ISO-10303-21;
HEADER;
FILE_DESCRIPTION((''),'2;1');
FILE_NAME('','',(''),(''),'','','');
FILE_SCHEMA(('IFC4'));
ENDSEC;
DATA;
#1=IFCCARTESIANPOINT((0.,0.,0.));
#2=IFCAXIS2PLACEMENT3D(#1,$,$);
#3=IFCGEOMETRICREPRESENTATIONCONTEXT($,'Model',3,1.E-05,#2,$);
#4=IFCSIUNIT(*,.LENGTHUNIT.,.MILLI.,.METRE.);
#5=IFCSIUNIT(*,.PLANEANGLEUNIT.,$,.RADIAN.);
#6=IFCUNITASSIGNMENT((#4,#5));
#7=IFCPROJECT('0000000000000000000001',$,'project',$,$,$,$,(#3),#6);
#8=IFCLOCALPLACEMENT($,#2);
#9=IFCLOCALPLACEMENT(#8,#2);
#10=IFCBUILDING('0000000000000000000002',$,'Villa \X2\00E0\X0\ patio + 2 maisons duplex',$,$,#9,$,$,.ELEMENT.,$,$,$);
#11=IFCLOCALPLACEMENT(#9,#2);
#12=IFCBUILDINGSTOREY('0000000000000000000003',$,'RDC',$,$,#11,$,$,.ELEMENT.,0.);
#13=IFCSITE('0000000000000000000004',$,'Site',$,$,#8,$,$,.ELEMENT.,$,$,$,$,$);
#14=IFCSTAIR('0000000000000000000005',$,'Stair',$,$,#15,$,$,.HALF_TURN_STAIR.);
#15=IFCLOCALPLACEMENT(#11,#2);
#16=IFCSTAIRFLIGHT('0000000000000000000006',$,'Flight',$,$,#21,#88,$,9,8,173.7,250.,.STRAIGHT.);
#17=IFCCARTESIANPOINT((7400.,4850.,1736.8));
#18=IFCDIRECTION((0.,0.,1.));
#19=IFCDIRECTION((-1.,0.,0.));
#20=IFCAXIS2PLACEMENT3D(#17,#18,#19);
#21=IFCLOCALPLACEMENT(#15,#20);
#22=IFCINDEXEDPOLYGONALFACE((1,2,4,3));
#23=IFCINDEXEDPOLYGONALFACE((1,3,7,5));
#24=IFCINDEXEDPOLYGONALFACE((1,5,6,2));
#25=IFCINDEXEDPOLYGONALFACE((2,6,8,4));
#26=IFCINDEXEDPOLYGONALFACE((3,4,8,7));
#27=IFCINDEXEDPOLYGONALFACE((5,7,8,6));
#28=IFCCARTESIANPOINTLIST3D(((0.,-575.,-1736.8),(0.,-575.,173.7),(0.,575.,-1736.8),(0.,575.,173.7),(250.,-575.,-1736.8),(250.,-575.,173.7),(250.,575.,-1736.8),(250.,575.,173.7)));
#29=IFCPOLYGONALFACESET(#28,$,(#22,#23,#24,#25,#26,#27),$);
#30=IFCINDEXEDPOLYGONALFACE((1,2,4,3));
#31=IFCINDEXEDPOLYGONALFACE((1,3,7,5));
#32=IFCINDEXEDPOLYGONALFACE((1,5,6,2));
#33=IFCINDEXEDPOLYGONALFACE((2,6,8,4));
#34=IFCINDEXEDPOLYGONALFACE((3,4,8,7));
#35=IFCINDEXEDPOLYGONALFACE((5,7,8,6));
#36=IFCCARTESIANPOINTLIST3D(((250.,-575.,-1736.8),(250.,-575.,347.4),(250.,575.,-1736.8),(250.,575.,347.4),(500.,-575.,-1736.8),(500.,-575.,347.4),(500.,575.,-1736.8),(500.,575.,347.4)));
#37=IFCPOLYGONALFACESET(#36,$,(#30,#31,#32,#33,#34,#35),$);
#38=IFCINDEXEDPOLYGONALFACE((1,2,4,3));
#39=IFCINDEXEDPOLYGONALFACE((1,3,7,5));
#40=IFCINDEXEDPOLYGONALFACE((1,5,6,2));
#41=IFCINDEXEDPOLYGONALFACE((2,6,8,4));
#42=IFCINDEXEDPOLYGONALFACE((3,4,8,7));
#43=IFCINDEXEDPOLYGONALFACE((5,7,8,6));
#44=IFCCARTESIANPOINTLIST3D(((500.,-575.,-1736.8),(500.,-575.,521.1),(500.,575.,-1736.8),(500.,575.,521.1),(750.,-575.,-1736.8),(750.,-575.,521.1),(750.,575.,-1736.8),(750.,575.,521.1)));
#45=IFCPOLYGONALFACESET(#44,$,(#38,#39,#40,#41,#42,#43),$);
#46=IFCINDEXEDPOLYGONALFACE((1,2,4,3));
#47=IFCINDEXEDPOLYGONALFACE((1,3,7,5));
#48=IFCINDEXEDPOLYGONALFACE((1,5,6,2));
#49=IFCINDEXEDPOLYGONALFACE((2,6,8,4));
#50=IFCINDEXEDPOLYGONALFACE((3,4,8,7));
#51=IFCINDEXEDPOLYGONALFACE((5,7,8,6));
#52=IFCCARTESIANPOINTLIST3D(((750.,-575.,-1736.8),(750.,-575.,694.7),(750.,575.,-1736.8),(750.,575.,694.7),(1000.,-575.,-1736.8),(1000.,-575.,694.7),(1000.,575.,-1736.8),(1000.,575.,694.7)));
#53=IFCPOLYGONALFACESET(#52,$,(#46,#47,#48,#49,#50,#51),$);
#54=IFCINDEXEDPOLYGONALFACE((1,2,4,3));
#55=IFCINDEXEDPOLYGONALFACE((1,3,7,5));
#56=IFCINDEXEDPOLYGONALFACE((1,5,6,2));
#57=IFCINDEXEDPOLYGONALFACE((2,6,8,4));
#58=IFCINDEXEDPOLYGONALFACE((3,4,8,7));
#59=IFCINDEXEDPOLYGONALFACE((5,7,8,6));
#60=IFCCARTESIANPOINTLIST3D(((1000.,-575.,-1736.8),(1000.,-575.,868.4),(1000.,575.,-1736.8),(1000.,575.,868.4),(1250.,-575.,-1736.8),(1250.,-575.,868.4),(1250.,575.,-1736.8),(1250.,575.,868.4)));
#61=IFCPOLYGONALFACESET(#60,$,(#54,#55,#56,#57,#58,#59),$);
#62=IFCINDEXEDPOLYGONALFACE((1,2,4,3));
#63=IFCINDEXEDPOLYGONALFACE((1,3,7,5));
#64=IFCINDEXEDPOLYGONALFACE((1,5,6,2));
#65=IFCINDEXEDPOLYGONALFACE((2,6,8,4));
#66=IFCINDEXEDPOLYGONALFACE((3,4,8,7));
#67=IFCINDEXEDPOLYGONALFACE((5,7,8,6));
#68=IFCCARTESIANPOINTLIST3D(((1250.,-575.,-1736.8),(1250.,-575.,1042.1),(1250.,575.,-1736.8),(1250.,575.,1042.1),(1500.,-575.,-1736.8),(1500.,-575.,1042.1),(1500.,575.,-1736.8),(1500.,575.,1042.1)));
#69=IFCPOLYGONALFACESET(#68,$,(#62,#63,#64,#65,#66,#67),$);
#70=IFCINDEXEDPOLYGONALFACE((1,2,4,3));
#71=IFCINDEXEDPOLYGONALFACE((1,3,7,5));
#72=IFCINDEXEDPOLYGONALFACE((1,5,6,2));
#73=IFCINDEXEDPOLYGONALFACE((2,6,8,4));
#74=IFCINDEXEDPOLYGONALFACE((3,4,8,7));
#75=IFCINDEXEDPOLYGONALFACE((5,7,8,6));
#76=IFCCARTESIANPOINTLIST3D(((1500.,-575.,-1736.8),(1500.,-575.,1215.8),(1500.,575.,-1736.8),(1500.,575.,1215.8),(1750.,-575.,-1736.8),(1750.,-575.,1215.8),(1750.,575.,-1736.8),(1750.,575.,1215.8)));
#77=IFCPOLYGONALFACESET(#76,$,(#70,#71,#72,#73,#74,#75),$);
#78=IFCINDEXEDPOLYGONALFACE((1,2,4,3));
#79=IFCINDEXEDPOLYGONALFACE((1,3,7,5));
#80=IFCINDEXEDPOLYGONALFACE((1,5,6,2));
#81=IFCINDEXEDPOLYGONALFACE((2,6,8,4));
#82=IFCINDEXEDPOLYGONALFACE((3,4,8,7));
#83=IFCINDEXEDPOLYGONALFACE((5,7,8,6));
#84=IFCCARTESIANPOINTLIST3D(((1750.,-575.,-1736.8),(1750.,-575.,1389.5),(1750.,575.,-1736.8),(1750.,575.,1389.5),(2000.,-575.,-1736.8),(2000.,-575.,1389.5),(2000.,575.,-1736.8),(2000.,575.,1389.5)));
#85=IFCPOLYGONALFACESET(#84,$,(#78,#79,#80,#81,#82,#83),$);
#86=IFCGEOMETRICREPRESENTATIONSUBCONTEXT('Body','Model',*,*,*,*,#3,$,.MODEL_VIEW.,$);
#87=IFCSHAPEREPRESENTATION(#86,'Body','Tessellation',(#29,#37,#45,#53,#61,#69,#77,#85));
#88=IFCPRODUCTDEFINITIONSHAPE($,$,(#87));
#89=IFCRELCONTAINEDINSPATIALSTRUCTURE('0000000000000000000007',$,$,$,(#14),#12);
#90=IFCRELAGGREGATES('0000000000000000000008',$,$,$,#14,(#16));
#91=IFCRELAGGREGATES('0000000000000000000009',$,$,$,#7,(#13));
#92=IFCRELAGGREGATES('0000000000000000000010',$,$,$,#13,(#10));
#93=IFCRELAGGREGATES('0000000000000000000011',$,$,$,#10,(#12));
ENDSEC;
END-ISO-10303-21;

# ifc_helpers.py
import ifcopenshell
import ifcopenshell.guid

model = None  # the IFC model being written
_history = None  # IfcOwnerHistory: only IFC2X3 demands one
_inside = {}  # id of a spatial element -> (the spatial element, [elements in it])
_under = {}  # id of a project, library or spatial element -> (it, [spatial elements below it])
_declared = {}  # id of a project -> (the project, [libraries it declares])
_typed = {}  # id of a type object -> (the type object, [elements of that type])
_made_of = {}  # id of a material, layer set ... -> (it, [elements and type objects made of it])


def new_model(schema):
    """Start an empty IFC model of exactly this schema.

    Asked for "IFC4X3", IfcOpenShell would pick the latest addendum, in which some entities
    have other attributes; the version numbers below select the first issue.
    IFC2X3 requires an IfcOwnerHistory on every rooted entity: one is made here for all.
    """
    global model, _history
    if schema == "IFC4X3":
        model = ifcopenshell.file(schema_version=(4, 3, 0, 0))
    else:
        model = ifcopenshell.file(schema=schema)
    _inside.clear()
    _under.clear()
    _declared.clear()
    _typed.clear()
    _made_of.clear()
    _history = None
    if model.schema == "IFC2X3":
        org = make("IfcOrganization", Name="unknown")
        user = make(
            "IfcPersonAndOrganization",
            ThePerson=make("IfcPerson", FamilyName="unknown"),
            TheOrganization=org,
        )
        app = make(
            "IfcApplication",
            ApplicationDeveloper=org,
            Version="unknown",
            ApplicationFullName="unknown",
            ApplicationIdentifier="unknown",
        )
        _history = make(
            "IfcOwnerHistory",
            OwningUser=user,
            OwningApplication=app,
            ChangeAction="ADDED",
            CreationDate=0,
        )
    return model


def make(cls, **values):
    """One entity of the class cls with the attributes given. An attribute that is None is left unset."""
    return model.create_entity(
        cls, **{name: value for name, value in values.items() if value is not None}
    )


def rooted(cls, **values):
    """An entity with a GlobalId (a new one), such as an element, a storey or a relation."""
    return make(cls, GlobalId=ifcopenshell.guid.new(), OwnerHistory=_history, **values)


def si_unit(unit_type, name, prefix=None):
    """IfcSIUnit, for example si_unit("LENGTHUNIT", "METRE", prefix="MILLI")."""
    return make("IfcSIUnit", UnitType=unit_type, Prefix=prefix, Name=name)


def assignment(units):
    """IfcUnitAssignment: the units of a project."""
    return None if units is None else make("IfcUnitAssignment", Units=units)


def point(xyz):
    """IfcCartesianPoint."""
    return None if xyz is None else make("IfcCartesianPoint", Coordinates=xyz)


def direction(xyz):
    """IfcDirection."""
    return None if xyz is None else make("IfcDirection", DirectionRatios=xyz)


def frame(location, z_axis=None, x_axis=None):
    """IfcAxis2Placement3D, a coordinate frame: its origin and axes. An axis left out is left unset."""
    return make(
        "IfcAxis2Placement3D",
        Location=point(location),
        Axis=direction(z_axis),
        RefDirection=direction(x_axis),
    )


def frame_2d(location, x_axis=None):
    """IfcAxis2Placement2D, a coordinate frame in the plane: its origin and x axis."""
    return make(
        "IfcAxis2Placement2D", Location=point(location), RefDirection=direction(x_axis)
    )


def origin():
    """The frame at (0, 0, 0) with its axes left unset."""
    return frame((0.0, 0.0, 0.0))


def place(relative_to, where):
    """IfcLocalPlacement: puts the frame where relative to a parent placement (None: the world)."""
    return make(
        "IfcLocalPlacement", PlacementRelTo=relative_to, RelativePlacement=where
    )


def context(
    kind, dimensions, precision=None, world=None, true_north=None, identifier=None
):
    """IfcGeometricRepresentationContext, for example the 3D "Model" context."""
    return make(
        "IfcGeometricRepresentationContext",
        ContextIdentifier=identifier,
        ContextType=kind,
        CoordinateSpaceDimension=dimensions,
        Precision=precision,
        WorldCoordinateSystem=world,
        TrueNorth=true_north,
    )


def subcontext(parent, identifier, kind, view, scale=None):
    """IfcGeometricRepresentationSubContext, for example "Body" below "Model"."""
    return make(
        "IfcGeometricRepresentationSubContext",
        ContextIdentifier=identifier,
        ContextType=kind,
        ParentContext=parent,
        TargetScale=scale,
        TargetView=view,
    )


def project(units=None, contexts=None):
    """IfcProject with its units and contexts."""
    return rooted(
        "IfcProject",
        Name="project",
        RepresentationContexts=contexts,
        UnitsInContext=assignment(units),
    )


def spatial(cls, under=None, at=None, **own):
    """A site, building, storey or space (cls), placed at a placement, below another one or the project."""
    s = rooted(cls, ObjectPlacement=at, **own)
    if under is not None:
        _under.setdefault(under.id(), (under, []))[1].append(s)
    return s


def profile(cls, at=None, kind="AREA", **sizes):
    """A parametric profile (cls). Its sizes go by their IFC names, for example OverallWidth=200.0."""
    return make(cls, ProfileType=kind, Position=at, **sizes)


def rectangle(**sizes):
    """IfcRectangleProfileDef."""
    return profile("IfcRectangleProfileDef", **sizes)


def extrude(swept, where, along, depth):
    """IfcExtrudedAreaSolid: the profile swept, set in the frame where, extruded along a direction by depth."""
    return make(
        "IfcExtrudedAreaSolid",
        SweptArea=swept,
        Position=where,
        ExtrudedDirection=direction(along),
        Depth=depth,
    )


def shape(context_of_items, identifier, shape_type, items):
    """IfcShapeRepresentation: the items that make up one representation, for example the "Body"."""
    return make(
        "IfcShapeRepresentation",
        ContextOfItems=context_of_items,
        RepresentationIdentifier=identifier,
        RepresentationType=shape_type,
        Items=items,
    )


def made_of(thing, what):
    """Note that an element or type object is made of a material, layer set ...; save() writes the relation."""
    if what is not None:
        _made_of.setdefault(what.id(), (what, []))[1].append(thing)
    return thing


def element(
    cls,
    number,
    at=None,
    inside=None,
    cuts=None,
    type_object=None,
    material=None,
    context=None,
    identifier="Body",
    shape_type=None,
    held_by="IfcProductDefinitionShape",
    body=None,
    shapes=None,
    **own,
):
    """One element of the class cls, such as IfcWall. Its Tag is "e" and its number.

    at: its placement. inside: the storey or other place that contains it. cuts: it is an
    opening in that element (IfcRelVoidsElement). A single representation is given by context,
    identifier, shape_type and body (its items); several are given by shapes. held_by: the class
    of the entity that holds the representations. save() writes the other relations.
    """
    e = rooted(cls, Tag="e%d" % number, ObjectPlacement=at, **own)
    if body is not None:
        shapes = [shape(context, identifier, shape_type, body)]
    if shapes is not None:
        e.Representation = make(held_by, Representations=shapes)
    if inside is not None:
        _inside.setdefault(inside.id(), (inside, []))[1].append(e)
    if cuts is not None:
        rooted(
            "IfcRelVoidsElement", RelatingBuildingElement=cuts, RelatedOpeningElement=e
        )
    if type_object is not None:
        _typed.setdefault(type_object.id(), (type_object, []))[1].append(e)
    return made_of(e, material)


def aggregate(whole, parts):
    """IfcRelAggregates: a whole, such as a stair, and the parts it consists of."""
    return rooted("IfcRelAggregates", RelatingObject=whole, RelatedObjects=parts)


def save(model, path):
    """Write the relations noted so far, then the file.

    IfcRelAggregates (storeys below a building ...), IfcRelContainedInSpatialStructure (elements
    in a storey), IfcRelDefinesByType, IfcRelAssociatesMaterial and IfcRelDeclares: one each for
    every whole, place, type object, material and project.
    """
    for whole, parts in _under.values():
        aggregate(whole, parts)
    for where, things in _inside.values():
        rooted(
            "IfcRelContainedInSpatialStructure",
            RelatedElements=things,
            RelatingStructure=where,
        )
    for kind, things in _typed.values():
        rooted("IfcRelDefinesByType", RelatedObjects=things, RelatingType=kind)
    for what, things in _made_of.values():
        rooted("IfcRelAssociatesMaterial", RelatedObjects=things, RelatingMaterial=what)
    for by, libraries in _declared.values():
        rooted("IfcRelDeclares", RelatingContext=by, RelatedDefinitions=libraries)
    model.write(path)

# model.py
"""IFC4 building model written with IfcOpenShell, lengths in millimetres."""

from ifc_helpers import new_model, si_unit, frame, frame_2d, origin, place, context, subcontext, project, spatial, rectangle, extrude, element, aggregate, save


model = new_model("IFC4")

# Units and contexts
model_context = context("Model", 3, precision=1e-05, world=origin())
body_context = subcontext(model_context, "Body", "Model", "MODEL_VIEW")
ifc_project = project(units=[si_unit("LENGTHUNIT", "METRE", prefix="MILLI"), si_unit("PLANEANGLEUNIT", "RADIAN")], contexts=[model_context])

# Site, building, storey
site_placement = place(None, origin())
site = spatial("IfcSite", under=ifc_project, at=site_placement, Name="Site", CompositionType="ELEMENT")
building_placement = place(site_placement, origin())
building = spatial("IfcBuilding", under=site, at=building_placement, Name="Villa à patio + 2 maisons duplex", CompositionType="ELEMENT")
storey_placement = place(building_placement, origin())
storey = spatial("IfcBuildingStorey", under=building, at=storey_placement, Name="RDC", CompositionType="ELEMENT", Elevation=0.0)

# Stair, stair flight
stair_placement = place(storey_placement, origin())
stair = element("IfcStair", 1, at=stair_placement, inside=storey, Name="Stair", PredefinedType="HALF_TURN_STAIR")
stair_flight_1_placement = place(stair_placement, frame((7400.0, 4850.0, 1736.8), z_axis=(0.0, 0.0, 1.0), x_axis=(-1.0, 0.0, 0.0)))
stair_flight_1 = element("IfcStairFlight", 2, at=stair_flight_1_placement, Name="Flight", NumberOfRisers=9, NumberOfTreads=8, PredefinedType="STRAIGHT", RiserHeight=173.7, TreadLength=250.0, context=body_context, shape_type="SweptSolid", body=[
    extrude(rectangle(XDim=250.0, YDim=1150.0, at=frame_2d((125.0, 0.0))), frame((0.0, 0.0, -1736.8)), (0.0, 0.0, 1.0), 1910.5),
    extrude(rectangle(XDim=250.0, YDim=1150.0, at=frame_2d((375.0, 0.0))), frame((0.0, 0.0, -1736.8)), (0.0, 0.0, 1.0), 2084.2),
    extrude(rectangle(XDim=250.0, YDim=1150.0, at=frame_2d((625.0, 0.0))), frame((0.0, 0.0, -1736.8)), (0.0, 0.0, 1.0), 2257.9),
    extrude(rectangle(XDim=250.0, YDim=1150.0, at=frame_2d((875.0, 0.0))), frame((0.0, 0.0, -1736.8)), (0.0, 0.0, 1.0), 2431.6),
    extrude(rectangle(XDim=250.0, YDim=1150.0, at=frame_2d((1125.0, 0.0))), frame((0.0, 0.0, -1736.8)), (0.0, 0.0, 1.0), 2605.3),
    extrude(rectangle(XDim=250.0, YDim=1150.0, at=frame_2d((1375.0, 0.0))), frame((0.0, 0.0, -1736.8)), (0.0, 0.0, 1.0), 2778.9),
    extrude(rectangle(XDim=250.0, YDim=1150.0, at=frame_2d((1625.0, 0.0))), frame((0.0, 0.0, -1736.8)), (0.0, 0.0, 1.0), 2952.6),
    extrude(rectangle(XDim=250.0, YDim=1150.0, at=frame_2d((1875.0, 0.0))), frame((0.0, 0.0, -1736.8)), (0.0, 0.0, 1.0), 3126.3),
])
aggregate(stair, [stair_flight_1])

save(model, "model.ifc")
